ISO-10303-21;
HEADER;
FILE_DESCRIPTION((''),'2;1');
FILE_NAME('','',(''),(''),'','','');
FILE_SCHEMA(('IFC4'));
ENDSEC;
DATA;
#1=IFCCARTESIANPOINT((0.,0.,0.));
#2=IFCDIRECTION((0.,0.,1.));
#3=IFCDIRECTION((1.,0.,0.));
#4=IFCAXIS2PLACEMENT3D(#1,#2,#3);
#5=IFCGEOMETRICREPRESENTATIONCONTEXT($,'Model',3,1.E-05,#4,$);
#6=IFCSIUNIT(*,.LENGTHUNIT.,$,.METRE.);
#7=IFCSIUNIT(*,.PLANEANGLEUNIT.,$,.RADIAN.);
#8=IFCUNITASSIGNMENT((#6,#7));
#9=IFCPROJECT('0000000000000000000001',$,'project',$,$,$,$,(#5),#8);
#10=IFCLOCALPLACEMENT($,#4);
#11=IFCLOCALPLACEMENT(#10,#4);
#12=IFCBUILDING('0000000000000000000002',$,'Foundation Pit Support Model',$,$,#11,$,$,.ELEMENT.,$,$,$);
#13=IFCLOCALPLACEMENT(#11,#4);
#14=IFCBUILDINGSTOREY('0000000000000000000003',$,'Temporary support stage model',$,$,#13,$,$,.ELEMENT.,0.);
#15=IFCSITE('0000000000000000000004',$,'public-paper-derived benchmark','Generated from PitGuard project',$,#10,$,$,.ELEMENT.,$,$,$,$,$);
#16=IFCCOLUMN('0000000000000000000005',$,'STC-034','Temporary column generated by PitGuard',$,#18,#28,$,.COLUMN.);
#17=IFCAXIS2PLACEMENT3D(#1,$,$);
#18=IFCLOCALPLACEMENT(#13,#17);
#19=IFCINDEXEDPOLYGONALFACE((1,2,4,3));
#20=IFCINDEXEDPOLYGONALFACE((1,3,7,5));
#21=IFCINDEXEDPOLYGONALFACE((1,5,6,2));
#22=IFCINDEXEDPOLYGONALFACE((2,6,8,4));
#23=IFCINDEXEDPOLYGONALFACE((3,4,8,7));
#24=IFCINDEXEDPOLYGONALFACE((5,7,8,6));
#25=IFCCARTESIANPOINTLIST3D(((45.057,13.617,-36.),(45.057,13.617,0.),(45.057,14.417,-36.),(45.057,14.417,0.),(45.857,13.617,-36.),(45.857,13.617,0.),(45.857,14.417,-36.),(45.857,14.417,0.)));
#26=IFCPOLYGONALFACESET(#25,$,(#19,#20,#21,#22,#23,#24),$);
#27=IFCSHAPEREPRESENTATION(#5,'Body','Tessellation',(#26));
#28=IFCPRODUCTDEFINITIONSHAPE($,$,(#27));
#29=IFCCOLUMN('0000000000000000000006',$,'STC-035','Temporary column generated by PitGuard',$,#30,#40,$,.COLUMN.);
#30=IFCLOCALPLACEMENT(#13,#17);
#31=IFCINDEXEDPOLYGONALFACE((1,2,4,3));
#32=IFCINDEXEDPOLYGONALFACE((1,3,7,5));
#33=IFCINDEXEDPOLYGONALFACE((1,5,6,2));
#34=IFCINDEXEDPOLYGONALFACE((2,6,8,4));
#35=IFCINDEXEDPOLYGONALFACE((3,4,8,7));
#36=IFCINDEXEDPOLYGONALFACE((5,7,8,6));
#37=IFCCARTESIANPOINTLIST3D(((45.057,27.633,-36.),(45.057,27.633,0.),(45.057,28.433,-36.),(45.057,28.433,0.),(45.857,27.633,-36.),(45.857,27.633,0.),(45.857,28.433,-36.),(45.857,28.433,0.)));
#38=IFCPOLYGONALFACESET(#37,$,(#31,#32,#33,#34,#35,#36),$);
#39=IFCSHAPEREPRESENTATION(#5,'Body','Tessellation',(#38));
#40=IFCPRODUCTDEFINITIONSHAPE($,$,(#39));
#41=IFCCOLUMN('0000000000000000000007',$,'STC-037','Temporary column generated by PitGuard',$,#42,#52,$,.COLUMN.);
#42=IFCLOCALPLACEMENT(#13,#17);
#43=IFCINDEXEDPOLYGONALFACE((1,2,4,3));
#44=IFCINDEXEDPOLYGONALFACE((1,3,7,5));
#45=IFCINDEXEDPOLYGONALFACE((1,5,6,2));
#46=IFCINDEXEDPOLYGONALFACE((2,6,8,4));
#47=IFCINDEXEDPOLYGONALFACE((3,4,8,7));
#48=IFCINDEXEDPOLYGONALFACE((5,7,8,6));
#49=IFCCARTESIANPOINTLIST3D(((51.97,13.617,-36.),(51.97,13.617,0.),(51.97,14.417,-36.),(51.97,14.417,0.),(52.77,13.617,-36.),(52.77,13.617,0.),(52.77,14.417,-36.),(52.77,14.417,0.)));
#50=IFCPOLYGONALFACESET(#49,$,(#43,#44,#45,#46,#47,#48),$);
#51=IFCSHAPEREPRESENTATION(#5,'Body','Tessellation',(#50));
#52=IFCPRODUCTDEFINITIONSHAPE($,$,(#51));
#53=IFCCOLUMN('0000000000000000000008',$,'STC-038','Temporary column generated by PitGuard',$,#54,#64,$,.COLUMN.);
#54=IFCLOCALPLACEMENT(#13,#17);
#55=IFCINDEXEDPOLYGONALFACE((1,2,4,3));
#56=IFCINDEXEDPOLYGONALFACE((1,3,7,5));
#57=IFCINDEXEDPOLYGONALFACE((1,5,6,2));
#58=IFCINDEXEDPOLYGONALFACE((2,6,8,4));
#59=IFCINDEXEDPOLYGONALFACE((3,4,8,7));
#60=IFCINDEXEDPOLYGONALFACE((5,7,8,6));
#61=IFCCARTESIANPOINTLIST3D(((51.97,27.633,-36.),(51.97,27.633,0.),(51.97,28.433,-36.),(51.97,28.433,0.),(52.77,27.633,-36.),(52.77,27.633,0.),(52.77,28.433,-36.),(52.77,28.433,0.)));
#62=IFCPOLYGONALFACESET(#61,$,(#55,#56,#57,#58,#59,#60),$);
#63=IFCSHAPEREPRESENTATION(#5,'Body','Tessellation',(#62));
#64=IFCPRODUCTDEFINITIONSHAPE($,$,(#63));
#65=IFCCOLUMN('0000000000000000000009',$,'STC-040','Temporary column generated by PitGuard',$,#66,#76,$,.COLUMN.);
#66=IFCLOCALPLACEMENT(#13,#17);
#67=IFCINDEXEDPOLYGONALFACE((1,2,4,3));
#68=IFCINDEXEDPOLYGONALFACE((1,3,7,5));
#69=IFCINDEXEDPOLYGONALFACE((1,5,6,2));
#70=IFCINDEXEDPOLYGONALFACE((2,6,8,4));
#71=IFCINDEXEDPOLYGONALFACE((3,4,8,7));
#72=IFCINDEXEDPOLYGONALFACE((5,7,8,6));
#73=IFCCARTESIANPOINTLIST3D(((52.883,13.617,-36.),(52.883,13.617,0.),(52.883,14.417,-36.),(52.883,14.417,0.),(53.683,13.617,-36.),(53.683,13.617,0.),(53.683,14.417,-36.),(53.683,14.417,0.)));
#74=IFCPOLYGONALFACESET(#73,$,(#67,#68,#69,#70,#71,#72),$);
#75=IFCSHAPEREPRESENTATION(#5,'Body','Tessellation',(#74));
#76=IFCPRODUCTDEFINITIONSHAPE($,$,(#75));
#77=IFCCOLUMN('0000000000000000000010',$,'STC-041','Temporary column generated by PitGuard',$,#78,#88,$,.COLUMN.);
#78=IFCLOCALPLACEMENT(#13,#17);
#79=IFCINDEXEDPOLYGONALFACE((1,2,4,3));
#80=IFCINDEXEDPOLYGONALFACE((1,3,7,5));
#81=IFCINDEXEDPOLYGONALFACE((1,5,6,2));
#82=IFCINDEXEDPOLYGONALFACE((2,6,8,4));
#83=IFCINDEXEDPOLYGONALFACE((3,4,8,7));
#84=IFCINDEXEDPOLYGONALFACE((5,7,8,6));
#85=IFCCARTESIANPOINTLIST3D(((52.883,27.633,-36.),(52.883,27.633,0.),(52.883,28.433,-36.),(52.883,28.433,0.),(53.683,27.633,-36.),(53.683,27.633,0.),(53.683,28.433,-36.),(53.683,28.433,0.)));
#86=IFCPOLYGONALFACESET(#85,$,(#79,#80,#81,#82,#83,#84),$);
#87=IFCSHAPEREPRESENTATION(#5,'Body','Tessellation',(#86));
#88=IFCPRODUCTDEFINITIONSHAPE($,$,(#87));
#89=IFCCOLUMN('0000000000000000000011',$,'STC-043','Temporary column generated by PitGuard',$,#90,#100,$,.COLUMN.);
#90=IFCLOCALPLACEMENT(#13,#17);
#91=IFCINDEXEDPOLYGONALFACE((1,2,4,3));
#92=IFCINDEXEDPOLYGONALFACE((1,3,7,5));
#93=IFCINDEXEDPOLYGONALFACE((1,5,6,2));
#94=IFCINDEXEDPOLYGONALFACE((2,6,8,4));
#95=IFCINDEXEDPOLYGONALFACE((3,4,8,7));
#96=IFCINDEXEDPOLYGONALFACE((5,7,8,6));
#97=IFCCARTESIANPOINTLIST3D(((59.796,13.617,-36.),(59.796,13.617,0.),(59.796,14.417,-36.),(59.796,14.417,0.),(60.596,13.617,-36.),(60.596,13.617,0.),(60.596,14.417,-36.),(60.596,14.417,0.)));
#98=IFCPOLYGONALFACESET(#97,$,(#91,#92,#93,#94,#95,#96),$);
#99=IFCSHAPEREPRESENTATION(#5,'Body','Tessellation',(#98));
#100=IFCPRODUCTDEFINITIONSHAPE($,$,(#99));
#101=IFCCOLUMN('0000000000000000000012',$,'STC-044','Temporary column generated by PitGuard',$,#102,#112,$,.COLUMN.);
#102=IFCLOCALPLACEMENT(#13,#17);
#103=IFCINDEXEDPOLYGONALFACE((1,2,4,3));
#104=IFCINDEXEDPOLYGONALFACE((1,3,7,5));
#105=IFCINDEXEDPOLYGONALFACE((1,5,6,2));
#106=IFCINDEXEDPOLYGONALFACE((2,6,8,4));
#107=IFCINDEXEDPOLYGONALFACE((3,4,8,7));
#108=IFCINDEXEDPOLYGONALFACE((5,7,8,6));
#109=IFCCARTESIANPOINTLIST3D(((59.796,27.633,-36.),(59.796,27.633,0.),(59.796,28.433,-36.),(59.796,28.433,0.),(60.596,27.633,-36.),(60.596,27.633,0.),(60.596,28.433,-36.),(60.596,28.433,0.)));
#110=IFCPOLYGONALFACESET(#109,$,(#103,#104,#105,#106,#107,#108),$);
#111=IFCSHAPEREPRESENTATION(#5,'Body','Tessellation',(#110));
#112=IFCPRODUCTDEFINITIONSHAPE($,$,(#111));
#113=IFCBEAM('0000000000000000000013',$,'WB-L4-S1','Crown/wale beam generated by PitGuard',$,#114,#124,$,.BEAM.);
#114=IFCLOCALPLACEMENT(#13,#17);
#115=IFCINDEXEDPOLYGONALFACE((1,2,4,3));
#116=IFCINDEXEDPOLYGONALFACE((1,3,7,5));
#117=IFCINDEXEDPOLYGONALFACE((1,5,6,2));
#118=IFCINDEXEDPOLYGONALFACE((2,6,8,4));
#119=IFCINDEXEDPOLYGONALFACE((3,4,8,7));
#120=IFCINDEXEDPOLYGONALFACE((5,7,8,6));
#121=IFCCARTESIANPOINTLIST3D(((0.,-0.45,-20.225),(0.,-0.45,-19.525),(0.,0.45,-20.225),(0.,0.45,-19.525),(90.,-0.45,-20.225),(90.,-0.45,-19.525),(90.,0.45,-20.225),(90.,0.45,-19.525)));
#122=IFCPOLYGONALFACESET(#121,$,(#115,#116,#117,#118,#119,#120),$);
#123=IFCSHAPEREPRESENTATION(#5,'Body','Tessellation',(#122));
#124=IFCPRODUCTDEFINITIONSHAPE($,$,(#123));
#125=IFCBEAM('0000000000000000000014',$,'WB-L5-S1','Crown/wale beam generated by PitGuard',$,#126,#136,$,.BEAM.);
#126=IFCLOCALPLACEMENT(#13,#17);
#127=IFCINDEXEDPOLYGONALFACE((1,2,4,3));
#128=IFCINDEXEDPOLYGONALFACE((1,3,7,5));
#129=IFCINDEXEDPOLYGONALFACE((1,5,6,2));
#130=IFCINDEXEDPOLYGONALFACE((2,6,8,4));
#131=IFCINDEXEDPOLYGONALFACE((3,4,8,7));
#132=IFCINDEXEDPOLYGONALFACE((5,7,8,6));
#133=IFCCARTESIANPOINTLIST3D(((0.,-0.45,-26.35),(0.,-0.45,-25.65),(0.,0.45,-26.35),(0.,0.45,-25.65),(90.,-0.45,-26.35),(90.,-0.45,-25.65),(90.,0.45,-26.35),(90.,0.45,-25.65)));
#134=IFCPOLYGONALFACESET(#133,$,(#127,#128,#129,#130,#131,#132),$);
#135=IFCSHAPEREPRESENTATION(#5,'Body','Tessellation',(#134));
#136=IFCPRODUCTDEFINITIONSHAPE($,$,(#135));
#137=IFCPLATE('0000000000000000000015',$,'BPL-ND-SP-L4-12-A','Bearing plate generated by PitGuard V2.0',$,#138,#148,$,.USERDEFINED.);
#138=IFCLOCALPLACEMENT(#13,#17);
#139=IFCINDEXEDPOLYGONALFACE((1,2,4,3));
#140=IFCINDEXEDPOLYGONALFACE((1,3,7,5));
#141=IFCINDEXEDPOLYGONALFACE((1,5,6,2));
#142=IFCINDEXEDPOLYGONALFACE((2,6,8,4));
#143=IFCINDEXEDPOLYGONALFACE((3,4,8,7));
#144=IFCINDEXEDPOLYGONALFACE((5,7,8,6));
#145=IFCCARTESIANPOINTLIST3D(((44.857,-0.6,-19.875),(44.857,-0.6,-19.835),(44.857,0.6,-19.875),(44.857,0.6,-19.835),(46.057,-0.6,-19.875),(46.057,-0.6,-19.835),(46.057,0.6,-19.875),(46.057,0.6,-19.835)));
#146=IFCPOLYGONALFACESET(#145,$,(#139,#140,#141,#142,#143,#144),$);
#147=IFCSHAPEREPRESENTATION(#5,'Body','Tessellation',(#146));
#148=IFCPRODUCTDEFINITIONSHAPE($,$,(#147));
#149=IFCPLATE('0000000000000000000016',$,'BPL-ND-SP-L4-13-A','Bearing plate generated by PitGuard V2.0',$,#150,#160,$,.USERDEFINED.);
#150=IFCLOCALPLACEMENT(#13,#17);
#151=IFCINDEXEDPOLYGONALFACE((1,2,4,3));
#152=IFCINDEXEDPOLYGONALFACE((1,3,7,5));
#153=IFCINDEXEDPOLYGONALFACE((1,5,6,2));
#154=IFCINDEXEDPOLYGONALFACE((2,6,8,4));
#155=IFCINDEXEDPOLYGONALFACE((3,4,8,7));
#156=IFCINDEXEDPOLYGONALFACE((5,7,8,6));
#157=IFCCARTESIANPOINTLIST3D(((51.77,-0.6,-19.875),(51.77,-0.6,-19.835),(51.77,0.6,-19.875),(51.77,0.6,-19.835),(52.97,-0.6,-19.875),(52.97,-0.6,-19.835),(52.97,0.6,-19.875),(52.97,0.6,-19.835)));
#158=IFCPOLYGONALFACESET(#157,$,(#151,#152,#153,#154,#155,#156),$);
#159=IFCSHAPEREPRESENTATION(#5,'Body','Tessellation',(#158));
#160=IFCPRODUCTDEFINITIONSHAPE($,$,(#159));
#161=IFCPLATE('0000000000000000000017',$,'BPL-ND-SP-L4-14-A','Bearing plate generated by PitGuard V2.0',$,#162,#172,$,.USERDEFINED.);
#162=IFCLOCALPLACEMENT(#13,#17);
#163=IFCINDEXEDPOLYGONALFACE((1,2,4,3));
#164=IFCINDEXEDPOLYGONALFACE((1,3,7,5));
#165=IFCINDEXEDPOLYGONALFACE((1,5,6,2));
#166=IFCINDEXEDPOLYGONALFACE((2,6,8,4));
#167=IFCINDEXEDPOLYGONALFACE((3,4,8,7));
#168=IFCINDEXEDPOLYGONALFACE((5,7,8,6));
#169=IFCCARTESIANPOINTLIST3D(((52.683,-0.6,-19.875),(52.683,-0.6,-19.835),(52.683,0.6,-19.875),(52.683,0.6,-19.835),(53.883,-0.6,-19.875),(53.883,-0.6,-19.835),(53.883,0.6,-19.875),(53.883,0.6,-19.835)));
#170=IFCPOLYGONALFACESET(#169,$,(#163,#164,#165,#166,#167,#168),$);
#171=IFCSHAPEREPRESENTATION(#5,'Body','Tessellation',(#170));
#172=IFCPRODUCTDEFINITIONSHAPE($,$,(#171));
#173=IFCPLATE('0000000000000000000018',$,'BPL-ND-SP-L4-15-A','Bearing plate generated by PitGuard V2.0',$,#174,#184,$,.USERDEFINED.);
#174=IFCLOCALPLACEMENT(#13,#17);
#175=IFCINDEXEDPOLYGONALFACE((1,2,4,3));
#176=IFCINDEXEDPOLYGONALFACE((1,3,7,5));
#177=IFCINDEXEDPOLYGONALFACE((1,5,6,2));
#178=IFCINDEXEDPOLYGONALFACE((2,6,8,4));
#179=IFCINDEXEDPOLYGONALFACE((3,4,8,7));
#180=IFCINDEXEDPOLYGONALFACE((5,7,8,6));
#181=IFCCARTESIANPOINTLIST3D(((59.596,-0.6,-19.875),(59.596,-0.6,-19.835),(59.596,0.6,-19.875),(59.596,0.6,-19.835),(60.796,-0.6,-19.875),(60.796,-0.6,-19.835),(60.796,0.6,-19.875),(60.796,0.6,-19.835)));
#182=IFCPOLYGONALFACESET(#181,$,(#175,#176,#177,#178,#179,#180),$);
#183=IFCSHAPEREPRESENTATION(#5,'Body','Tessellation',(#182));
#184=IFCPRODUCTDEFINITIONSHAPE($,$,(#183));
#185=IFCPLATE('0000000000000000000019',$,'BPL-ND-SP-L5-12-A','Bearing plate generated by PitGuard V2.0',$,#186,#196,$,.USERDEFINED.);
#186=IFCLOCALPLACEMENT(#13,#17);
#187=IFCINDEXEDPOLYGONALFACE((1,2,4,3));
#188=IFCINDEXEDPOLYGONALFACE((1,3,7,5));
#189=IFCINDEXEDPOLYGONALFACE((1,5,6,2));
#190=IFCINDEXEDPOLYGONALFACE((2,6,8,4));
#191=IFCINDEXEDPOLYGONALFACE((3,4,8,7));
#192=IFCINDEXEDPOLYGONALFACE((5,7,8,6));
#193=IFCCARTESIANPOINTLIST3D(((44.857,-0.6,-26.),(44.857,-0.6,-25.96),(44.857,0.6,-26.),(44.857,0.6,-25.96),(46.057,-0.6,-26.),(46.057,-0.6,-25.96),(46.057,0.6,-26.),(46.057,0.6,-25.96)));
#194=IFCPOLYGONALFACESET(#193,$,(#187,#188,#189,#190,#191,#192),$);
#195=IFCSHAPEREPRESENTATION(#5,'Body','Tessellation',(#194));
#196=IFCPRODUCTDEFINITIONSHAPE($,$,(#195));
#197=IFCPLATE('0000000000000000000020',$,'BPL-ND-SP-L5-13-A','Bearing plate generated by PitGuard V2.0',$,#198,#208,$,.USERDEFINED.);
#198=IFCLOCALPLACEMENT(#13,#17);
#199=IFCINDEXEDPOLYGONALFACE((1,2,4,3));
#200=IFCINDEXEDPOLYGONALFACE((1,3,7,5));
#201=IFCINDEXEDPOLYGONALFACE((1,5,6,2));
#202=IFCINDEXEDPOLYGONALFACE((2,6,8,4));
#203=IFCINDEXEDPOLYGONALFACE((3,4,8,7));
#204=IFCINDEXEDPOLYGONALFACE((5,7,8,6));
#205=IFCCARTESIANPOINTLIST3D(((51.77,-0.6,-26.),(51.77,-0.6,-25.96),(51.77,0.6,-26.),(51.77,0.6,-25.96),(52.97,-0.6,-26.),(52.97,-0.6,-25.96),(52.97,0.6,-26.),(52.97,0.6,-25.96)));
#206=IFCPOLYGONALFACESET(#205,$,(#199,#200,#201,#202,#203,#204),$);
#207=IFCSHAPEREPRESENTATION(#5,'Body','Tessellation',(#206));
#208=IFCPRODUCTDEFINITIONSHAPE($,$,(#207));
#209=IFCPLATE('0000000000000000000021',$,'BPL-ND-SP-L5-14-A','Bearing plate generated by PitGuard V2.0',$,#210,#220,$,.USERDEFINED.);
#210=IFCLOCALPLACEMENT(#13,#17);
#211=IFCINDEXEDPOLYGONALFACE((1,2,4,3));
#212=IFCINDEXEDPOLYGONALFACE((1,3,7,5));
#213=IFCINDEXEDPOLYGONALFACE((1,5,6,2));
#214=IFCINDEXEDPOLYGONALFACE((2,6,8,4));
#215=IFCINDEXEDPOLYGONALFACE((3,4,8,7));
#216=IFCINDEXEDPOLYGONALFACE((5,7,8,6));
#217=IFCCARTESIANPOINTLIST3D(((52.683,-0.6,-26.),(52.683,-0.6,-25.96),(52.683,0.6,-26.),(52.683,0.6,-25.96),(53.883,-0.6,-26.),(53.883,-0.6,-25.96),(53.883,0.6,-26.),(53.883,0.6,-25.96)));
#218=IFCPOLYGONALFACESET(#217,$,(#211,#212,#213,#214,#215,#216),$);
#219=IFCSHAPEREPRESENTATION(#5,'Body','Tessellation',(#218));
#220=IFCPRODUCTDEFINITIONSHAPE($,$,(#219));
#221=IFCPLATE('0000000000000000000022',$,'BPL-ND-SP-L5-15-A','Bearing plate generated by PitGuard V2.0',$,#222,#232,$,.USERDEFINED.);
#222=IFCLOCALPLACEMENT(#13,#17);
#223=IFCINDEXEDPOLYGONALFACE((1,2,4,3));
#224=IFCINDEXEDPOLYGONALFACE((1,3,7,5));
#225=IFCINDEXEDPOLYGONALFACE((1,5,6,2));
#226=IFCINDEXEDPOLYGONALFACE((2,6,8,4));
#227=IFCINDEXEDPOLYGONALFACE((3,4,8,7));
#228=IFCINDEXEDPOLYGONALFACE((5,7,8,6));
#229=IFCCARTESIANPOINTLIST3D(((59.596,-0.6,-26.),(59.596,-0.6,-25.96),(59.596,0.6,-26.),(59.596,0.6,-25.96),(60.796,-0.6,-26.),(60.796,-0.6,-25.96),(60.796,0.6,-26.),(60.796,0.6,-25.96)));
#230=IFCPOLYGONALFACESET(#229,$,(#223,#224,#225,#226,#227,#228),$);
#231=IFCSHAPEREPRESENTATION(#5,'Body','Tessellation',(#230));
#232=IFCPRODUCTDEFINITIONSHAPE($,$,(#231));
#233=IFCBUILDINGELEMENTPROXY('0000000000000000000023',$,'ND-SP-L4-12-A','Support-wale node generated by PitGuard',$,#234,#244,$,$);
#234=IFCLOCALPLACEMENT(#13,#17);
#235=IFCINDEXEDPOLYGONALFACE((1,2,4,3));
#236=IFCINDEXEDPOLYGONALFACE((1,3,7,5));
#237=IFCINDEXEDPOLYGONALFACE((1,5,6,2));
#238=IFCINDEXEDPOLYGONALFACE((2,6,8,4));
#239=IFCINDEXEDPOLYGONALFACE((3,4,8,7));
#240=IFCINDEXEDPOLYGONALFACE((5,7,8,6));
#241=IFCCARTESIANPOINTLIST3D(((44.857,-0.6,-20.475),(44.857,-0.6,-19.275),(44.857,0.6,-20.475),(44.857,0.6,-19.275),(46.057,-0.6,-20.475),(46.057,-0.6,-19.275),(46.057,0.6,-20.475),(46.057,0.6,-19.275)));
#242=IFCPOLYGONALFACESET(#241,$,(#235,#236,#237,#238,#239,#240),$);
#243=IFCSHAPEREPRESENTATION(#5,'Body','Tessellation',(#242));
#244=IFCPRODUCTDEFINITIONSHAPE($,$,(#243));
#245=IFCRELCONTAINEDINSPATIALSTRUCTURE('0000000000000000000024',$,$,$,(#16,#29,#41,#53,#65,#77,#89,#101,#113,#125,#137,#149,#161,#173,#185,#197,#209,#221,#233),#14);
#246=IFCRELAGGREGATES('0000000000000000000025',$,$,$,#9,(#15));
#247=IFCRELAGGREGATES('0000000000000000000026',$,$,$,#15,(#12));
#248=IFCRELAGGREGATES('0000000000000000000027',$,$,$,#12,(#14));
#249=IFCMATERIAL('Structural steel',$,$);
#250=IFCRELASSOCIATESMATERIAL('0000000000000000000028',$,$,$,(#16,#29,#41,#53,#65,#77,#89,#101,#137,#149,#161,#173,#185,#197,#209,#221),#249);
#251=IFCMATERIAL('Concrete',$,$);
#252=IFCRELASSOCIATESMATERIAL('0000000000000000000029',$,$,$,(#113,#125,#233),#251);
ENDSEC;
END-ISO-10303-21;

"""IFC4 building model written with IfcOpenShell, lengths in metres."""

from ifc_helpers import new_model, si_unit, frame, origin_with_axes, origin_2d, place, context, project, spatial, rectangle, extrude, material, element, save


model = new_model("IFC4")

# Units and contexts
model_context = context("Model", 3, precision=1e-05, world=origin_with_axes())
ifc_project = project(units=[si_unit("LENGTHUNIT", "METRE"), si_unit("PLANEANGLEUNIT", "RADIAN")], contexts=[model_context])

# Site, building, storey
site_placement = place(None, origin_with_axes())
site = spatial("IfcSite", under=ifc_project, at=site_placement, Name="public-paper-derived benchmark", Description="Generated from PitGuard project", CompositionType="ELEMENT")
building_placement = place(site_placement, origin_with_axes())
building = spatial("IfcBuilding", under=site, at=building_placement, Name="Foundation Pit Support Model", CompositionType="ELEMENT")
storey_placement = place(building_placement, origin_with_axes())
storey = spatial("IfcBuildingStorey", under=building, at=storey_placement, Name="Temporary support stage model", CompositionType="ELEMENT", Elevation=0.0)

# Columns
ifc_material_1 = material(Name="Structural steel")
for number, where, z_axis, x_axis, name in (
    (1, (45.457, 14.017, -36.0), (0.0, 0.0, 1.0), (1.0, 0.0, 0.0), "STC-034"),
    (2, (45.457, 28.033, -36.0), (0.0, 0.0, 1.0), (1.0, 0.0, 0.0), "STC-035"),
    (3, (52.37, 14.017, -36.0), (0.0, 0.0, 1.0), (1.0, 0.0, 0.0), "STC-037"),
    (4, (52.37, 28.033, -36.0), (0.0, 0.0, 1.0), (1.0, 0.0, 0.0), "STC-038"),
    (5, (53.283, 14.017, -36.0), (0.0, 0.0, 1.0), (1.0, 0.0, 0.0), "STC-040"),
    (6, (53.283, 28.033, -36.0), (0.0, 0.0, 1.0), (1.0, 0.0, 0.0), "STC-041"),
    (7, (60.196, 14.017, -36.0), (0.0, 0.0, 1.0), (1.0, 0.0, 0.0), "STC-043"),
    (8, (60.196, 28.033, -36.0), (0.0, 0.0, 1.0), (1.0, 0.0, 0.0), "STC-044"),
):
    element("IfcColumn", number, at=place(storey_placement, frame(where, z_axis=z_axis, x_axis=x_axis)), inside=storey, material=ifc_material_1, Name=name, Description="Temporary column generated by PitGuard", PredefinedType="COLUMN", context=model_context, shape_type="SweptSolid", body=[
        extrude(rectangle(XDim=0.8, YDim=0.8, at=origin_2d()), origin_with_axes(), (0.0, 0.0, 1.0), 36.0),
    ])

# Beams
ifc_material_2 = material(Name="Concrete")
for number, where, z_axis, x_axis, name in (
    (9, (45.0, 0.0, -20.225), (0.0, 0.0, 1.0), (1.0, 0.0, 0.0), "WB-L4-S1"),
    (10, (45.0, 0.0, -26.35), (0.0, 0.0, 1.0), (1.0, 0.0, 0.0), "WB-L5-S1"),
):
    element("IfcBeam", number, at=place(storey_placement, frame(where, z_axis=z_axis, x_axis=x_axis)), inside=storey, material=ifc_material_2, Name=name, Description="Crown/wale beam generated by PitGuard", PredefinedType="BEAM", context=model_context, shape_type="SweptSolid", body=[
        extrude(rectangle(XDim=90.0, YDim=0.9, at=origin_2d()), origin_with_axes(), (0.0, 0.0, 1.0), 0.7),
    ])

# Plates
for number, where, z_axis, x_axis, name in (
    (11, (45.457, 0.0, -19.875), (0.0, 0.0, 1.0), (1.0, 0.0, 0.0), "BPL-ND-SP-L4-12-A"),
    (12, (52.37, 0.0, -19.875), (0.0, 0.0, 1.0), (1.0, 0.0, 0.0), "BPL-ND-SP-L4-13-A"),
    (13, (53.283, 0.0, -19.875), (0.0, 0.0, 1.0), (1.0, 0.0, 0.0), "BPL-ND-SP-L4-14-A"),
    (14, (60.196, 0.0, -19.875), (0.0, 0.0, 1.0), (1.0, 0.0, 0.0), "BPL-ND-SP-L4-15-A"),
    (15, (45.457, 0.0, -26.0), (0.0, 0.0, 1.0), (1.0, 0.0, 0.0), "BPL-ND-SP-L5-12-A"),
    (16, (52.37, 0.0, -26.0), (0.0, 0.0, 1.0), (1.0, 0.0, 0.0), "BPL-ND-SP-L5-13-A"),
    (17, (53.283, 0.0, -26.0), (0.0, 0.0, 1.0), (1.0, 0.0, 0.0), "BPL-ND-SP-L5-14-A"),
    (18, (60.196, 0.0, -26.0), (0.0, 0.0, 1.0), (1.0, 0.0, 0.0), "BPL-ND-SP-L5-15-A"),
):
    element("IfcPlate", number, at=place(storey_placement, frame(where, z_axis=z_axis, x_axis=x_axis)), inside=storey, material=ifc_material_1, Name=name, Description="Bearing plate generated by PitGuard V2.0", PredefinedType="USERDEFINED", context=model_context, shape_type="SweptSolid", body=[
        extrude(rectangle(XDim=1.2, YDim=1.2, at=origin_2d()), origin_with_axes(), (0.0, 0.0, 1.0), 0.04),
    ])

# Building element proxy
proxy_1_placement = place(storey_placement, frame((45.457, 0.0, -20.475), z_axis=(0.0, 0.0, 1.0), x_axis=(1.0, 0.0, 0.0)))
element("IfcBuildingElementProxy", 19, at=proxy_1_placement, inside=storey, material=ifc_material_2, Name="ND-SP-L4-12-A", Description="Support-wale node generated by PitGuard", context=model_context, shape_type="SweptSolid", body=[
    extrude(rectangle(XDim=1.2, YDim=1.2, at=origin_2d()), origin_with_axes(), (0.0, 0.0, 1.0), 1.2),
])

save(model, "model.ifc")
